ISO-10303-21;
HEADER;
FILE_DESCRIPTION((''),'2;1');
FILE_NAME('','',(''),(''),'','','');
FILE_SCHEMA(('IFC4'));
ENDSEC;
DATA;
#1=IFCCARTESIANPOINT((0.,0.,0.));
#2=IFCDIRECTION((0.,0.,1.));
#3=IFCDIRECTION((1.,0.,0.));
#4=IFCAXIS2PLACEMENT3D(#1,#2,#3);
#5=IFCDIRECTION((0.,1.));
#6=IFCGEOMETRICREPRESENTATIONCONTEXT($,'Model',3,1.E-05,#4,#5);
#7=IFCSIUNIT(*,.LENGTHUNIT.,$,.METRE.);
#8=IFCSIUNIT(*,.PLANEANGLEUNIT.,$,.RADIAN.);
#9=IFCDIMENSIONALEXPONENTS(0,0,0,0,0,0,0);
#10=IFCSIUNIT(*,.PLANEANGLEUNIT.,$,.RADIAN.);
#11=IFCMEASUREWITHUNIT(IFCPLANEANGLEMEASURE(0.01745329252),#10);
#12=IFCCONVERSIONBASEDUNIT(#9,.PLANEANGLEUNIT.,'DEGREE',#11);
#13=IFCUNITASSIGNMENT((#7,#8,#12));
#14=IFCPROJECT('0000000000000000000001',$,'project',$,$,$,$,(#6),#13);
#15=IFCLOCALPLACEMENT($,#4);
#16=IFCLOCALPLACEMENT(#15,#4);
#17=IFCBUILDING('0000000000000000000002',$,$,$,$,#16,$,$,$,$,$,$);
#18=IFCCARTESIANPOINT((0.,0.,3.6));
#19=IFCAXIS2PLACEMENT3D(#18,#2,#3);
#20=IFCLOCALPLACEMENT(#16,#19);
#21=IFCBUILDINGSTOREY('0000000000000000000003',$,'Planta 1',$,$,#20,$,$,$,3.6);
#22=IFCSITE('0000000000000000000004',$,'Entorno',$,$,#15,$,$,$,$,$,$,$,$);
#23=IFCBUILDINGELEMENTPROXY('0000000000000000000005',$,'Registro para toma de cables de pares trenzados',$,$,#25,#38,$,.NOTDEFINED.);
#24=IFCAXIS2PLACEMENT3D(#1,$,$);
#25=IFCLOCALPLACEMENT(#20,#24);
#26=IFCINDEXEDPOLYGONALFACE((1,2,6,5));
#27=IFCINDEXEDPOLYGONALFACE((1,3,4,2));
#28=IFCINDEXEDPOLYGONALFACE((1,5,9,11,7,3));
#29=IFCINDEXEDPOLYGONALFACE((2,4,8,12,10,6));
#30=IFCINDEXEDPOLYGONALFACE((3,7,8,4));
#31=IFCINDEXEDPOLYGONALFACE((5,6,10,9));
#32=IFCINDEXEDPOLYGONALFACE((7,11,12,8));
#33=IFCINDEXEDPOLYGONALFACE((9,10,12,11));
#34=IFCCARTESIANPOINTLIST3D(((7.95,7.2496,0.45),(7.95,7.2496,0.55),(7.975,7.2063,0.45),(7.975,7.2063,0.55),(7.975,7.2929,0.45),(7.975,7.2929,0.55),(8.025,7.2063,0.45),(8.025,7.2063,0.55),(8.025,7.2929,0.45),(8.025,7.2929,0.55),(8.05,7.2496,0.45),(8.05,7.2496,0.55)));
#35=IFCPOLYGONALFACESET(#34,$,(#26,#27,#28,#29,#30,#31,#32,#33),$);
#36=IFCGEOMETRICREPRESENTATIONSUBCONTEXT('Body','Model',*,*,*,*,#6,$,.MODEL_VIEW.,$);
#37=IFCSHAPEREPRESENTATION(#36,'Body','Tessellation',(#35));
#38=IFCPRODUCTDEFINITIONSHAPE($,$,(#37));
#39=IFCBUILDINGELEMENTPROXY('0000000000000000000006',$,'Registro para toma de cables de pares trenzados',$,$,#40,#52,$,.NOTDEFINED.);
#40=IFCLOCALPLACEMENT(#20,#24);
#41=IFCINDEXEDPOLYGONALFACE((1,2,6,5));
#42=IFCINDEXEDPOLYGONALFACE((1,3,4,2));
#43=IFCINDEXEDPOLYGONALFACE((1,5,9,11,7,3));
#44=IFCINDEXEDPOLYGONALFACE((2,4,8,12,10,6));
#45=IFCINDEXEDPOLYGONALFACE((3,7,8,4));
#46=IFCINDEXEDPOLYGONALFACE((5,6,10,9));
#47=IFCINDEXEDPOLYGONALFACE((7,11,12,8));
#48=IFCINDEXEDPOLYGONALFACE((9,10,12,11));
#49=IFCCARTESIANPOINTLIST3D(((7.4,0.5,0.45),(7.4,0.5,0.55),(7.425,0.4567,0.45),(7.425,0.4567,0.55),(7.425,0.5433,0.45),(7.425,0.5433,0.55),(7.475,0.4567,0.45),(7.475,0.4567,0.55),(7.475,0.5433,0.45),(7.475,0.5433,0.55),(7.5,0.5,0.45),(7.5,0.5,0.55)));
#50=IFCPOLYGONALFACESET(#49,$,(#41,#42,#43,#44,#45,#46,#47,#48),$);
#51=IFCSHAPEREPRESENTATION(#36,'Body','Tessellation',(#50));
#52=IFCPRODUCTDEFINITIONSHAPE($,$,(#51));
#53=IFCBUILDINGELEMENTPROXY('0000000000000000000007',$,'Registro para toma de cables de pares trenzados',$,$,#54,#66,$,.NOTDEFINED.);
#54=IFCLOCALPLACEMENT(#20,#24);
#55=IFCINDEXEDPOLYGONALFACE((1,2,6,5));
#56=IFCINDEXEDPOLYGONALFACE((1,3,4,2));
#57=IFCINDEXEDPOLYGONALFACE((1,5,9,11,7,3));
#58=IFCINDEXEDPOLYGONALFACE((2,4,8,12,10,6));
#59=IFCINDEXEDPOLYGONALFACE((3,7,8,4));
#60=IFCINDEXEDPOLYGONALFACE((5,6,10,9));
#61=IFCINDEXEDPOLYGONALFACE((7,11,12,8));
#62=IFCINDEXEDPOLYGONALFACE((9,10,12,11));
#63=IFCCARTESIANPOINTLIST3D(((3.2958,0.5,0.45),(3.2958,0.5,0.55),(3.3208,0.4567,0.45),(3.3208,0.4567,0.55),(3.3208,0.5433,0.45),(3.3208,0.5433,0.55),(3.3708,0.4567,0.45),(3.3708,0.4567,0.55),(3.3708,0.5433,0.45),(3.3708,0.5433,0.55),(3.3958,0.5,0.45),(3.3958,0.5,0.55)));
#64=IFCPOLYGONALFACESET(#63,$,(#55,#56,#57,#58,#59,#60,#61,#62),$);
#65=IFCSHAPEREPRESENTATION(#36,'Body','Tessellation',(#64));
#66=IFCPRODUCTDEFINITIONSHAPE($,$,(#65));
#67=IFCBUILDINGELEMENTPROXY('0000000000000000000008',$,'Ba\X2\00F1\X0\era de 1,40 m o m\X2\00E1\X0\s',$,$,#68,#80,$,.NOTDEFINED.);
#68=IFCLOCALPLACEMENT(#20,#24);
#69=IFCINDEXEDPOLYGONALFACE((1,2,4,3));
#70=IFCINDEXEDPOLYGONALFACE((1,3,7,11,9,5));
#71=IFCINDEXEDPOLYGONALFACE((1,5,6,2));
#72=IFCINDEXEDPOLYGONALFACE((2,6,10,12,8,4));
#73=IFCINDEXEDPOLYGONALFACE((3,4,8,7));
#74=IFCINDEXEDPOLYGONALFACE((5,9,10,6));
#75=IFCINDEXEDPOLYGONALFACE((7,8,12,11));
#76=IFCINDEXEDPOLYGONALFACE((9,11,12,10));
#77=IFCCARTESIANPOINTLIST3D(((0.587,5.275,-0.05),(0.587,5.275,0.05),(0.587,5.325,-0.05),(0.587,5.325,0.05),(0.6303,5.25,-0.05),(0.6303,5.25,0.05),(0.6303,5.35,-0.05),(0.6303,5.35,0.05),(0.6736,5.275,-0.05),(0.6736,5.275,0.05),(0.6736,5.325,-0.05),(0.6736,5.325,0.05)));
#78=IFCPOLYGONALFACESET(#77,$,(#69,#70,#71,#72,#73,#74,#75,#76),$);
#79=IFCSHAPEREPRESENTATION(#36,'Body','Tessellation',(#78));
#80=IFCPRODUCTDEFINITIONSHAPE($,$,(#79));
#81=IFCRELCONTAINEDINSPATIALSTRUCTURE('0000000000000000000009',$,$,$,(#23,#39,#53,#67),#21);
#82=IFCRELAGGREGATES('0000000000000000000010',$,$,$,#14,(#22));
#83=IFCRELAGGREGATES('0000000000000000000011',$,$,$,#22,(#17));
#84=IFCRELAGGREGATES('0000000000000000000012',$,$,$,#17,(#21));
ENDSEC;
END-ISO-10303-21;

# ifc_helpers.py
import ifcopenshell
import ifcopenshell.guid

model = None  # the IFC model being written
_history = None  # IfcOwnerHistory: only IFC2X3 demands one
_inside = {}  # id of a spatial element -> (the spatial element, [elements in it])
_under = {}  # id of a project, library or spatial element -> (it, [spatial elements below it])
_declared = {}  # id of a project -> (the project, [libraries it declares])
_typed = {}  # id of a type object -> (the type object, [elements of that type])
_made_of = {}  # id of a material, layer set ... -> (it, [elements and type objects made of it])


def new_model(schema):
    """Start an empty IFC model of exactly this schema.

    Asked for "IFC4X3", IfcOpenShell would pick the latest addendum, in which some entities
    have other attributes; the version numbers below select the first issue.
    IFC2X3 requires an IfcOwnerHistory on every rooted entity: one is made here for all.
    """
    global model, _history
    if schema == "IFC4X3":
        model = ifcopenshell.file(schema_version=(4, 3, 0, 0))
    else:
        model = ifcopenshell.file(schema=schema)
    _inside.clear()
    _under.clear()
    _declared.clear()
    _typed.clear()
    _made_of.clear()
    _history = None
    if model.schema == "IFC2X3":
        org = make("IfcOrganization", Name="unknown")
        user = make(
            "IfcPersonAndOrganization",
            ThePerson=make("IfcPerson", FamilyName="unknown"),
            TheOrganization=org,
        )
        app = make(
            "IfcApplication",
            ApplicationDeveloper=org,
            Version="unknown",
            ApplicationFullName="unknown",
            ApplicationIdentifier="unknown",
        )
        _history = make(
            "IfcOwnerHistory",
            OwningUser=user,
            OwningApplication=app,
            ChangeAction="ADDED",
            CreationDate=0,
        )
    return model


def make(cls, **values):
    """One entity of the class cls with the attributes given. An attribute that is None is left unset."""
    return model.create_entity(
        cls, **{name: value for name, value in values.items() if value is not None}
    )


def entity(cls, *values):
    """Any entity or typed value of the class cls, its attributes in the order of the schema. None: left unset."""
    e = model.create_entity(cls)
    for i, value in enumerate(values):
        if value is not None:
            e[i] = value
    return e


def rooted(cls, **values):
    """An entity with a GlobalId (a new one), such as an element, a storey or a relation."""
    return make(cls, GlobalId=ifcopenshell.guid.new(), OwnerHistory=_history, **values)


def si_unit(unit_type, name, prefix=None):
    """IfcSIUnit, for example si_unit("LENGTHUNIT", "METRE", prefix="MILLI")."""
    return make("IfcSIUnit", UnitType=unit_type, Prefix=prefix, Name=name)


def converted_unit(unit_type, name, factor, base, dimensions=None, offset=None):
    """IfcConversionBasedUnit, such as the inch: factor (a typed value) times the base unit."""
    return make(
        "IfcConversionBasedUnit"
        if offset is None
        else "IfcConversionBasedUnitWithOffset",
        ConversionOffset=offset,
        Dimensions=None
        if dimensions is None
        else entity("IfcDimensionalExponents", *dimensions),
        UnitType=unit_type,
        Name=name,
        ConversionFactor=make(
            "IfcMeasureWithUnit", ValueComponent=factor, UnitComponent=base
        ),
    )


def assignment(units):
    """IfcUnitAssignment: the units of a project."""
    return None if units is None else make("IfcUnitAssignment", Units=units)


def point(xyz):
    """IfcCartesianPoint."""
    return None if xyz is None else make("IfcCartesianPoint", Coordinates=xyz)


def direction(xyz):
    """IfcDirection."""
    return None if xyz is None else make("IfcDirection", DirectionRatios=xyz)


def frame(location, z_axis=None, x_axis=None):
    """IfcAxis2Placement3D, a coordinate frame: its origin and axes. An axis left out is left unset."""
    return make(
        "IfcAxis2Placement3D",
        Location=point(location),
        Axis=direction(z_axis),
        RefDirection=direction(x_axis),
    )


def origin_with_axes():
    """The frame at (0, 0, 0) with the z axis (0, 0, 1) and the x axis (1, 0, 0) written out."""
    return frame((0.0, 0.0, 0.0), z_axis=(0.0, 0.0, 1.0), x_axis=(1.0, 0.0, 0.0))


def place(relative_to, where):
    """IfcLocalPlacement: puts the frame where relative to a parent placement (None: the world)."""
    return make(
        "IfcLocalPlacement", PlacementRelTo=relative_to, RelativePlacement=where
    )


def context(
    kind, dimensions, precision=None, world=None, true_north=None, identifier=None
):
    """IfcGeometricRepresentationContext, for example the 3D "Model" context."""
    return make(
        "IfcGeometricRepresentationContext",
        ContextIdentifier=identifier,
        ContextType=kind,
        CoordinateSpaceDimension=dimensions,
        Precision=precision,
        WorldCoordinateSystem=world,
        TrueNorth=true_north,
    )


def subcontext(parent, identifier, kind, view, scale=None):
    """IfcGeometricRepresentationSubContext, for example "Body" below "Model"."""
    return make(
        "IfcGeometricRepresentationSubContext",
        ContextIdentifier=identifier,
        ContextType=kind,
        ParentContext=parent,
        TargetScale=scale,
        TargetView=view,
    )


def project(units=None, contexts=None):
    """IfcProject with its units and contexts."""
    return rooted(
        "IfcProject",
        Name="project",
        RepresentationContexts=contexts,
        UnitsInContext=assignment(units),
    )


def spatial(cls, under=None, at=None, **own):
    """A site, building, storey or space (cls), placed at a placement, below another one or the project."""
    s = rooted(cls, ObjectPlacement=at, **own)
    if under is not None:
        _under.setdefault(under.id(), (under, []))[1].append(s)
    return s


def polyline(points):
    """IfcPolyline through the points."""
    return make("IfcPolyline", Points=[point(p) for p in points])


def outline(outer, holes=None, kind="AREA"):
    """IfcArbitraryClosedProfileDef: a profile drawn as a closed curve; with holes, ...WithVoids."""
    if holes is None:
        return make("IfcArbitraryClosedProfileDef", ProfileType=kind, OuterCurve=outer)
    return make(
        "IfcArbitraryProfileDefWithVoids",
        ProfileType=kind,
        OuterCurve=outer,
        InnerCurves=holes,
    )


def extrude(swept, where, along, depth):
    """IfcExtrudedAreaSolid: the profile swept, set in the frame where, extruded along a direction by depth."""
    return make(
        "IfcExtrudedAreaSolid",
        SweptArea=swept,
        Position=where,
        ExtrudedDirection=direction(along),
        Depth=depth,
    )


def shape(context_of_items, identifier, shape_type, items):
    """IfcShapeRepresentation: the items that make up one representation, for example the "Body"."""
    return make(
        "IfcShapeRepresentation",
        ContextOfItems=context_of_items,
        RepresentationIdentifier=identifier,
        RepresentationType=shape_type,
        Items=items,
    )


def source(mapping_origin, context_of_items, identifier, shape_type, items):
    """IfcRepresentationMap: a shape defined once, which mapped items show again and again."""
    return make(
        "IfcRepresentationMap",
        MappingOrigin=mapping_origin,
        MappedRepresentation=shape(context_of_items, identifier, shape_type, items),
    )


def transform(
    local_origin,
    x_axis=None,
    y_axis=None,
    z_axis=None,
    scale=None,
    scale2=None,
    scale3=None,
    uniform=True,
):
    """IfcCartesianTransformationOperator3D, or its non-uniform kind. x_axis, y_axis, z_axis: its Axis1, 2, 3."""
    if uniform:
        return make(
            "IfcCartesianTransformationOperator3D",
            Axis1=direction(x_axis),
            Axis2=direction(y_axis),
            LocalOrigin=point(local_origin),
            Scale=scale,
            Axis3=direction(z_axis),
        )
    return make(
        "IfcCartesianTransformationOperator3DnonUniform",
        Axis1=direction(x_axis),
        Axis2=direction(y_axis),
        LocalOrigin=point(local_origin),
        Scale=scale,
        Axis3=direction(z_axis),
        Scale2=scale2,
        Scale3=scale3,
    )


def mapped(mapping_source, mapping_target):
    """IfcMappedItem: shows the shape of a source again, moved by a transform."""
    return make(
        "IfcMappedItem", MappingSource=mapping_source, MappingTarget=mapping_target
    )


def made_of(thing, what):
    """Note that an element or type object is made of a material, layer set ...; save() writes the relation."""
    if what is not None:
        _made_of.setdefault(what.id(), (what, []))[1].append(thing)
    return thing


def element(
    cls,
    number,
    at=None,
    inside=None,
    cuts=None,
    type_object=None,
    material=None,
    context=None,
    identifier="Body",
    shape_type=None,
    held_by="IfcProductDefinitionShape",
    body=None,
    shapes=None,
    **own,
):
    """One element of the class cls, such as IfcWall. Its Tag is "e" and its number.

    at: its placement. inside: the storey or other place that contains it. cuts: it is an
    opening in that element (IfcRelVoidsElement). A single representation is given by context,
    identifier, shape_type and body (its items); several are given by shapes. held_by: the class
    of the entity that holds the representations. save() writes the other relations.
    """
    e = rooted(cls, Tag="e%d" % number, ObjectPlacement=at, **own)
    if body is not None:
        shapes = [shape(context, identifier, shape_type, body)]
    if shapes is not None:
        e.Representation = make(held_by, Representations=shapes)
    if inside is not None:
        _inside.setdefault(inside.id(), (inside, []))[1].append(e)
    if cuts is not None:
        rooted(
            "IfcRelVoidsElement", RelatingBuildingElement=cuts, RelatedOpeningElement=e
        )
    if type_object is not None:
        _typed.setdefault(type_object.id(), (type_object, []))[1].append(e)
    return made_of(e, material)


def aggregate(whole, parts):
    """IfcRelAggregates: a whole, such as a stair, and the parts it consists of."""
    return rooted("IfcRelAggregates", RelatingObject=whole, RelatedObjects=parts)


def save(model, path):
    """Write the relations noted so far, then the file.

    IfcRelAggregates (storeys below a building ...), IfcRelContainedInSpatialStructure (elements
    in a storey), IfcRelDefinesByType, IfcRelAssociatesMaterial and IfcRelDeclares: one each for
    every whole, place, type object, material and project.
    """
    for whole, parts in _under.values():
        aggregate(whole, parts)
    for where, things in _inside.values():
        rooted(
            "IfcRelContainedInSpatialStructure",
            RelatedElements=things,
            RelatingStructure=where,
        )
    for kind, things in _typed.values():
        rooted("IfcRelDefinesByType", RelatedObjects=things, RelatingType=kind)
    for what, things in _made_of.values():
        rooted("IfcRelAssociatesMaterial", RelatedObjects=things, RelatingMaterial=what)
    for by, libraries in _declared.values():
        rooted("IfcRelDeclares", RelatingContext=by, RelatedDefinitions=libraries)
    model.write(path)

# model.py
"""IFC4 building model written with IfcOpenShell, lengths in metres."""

from ifc_helpers import new_model, entity, si_unit, converted_unit, direction, frame, origin_with_axes, place, context, subcontext, project, spatial, polyline, outline, extrude, source, transform, mapped, element, save


model = new_model("IFC4")

# Units and contexts
model_context = context("Model", 3, precision=1e-05, world=origin_with_axes(), true_north=direction((0.0, 1.0)))
body_context = subcontext(model_context, "Body", "Model", "MODEL_VIEW")
ifc_project = project(units=[si_unit("LENGTHUNIT", "METRE"), si_unit("PLANEANGLEUNIT", "RADIAN"), converted_unit("PLANEANGLEUNIT", "DEGREE", entity("IfcPlaneAngleMeasure", 0.01745329252), si_unit("PLANEANGLEUNIT", "RADIAN"), dimensions=[0, 0, 0, 0, 0, 0, 0])], contexts=[model_context])

# Site, building, storey
site_placement = place(None, origin_with_axes())
site = spatial("IfcSite", under=ifc_project, at=site_placement, Name="Entorno")
building_placement = place(site_placement, origin_with_axes())
building = spatial("IfcBuilding", under=site, at=building_placement)
storey_placement = place(building_placement, frame((0.0, 0.0, 3.6), z_axis=(0.0, 0.0, 1.0), x_axis=(1.0, 0.0, 0.0)))
storey = spatial("IfcBuildingStorey", under=building, at=storey_placement, Name="Planta 1", Elevation=3.6)

# Building element proxies
shared_shape_1 = source(origin_with_axes(), body_context, "Body", "SolidModel", [
    extrude(outline(polyline([(0.05, 0.0), (0.025, 0.0433), (-0.025, 0.0433), (-0.05, 0.0), (-0.025, -0.0433), (0.025, -0.0433), (0.05, 0.0)])), frame((0.0, 0.0, -0.05), z_axis=(0.0, 0.0, 1.0), x_axis=(1.0, 0.0, 0.0)), (0.0, 0.0, 1.0), 0.1),
])
proxy_1_placement = place(storey_placement, frame((0.0, 0.0, -3.6), z_axis=(0.0, 0.0, 1.0), x_axis=(1.0, 0.0, 0.0)))
element("IfcBuildingElementProxy", 1, at=proxy_1_placement, inside=storey, Name="Registro para toma de cables de pares trenzados", PredefinedType="NOTDEFINED", context=body_context, shape_type="Brep", body=[
    mapped(shared_shape_1, transform((8.0, 7.2496, 4.1), x_axis=(1.0, 0.0, 0.0), y_axis=(0.0, 1.0, 0.0), z_axis=(0.0, 0.0, 1.0))),
])
proxy_2_placement = place(storey_placement, frame((0.0, 0.0, -3.6), z_axis=(0.0, 0.0, 1.0), x_axis=(1.0, 0.0, 0.0)))
element("IfcBuildingElementProxy", 2, at=proxy_2_placement, inside=storey, Name="Registro para toma de cables de pares trenzados", PredefinedType="NOTDEFINED", context=body_context, shape_type="Brep", body=[
    mapped(shared_shape_1, transform((7.45, 0.5, 4.1), x_axis=(1.0, 0.0, 0.0), y_axis=(0.0, 1.0, 0.0), z_axis=(0.0, 0.0, 1.0))),
])
proxy_3_placement = place(storey_placement, frame((0.0, 0.0, -3.6), z_axis=(0.0, 0.0, 1.0), x_axis=(1.0, 0.0, 0.0)))
element("IfcBuildingElementProxy", 3, at=proxy_3_placement, inside=storey, Name="Registro para toma de cables de pares trenzados", PredefinedType="NOTDEFINED", context=body_context, shape_type="Brep", body=[
    mapped(shared_shape_1, transform((3.3458, 0.5, 4.1), x_axis=(1.0, 0.0, 0.0), y_axis=(0.0, 1.0, 0.0), z_axis=(0.0, 0.0, 1.0))),
])
shared_shape_2 = source(origin_with_axes(), body_context, "Body", "SolidModel", [
    extrude(outline(polyline([(0.05, 0.0), (0.025, 0.0433), (-0.025, 0.0433), (-0.05, 0.0), (-0.025, -0.0433), (0.025, -0.0433), (0.05, 0.0)])), frame((0.0, 0.0, -0.05), z_axis=(0.0, 0.0, 1.0), x_axis=(1.0, 0.0, 0.0)), (0.0, 0.0, 1.0), 0.1),
])
proxy_4_placement = place(storey_placement, frame((0.0, 0.0, -3.6), z_axis=(0.0, 0.0, 1.0), x_axis=(1.0, 0.0, 0.0)))
element("IfcBuildingElementProxy", 4, at=proxy_4_placement, inside=storey, Name="Bañera de 1,40 m o más", PredefinedType="NOTDEFINED", context=body_context, shape_type="Brep", body=[
    mapped(shared_shape_2, transform((0.6303, 5.3, 3.6), x_axis=(0.0, -1.0, 0.0), y_axis=(1.0, 0.0, 0.0), z_axis=(0.0, 0.0, 1.0))),
])

save(model, "model.ifc")
